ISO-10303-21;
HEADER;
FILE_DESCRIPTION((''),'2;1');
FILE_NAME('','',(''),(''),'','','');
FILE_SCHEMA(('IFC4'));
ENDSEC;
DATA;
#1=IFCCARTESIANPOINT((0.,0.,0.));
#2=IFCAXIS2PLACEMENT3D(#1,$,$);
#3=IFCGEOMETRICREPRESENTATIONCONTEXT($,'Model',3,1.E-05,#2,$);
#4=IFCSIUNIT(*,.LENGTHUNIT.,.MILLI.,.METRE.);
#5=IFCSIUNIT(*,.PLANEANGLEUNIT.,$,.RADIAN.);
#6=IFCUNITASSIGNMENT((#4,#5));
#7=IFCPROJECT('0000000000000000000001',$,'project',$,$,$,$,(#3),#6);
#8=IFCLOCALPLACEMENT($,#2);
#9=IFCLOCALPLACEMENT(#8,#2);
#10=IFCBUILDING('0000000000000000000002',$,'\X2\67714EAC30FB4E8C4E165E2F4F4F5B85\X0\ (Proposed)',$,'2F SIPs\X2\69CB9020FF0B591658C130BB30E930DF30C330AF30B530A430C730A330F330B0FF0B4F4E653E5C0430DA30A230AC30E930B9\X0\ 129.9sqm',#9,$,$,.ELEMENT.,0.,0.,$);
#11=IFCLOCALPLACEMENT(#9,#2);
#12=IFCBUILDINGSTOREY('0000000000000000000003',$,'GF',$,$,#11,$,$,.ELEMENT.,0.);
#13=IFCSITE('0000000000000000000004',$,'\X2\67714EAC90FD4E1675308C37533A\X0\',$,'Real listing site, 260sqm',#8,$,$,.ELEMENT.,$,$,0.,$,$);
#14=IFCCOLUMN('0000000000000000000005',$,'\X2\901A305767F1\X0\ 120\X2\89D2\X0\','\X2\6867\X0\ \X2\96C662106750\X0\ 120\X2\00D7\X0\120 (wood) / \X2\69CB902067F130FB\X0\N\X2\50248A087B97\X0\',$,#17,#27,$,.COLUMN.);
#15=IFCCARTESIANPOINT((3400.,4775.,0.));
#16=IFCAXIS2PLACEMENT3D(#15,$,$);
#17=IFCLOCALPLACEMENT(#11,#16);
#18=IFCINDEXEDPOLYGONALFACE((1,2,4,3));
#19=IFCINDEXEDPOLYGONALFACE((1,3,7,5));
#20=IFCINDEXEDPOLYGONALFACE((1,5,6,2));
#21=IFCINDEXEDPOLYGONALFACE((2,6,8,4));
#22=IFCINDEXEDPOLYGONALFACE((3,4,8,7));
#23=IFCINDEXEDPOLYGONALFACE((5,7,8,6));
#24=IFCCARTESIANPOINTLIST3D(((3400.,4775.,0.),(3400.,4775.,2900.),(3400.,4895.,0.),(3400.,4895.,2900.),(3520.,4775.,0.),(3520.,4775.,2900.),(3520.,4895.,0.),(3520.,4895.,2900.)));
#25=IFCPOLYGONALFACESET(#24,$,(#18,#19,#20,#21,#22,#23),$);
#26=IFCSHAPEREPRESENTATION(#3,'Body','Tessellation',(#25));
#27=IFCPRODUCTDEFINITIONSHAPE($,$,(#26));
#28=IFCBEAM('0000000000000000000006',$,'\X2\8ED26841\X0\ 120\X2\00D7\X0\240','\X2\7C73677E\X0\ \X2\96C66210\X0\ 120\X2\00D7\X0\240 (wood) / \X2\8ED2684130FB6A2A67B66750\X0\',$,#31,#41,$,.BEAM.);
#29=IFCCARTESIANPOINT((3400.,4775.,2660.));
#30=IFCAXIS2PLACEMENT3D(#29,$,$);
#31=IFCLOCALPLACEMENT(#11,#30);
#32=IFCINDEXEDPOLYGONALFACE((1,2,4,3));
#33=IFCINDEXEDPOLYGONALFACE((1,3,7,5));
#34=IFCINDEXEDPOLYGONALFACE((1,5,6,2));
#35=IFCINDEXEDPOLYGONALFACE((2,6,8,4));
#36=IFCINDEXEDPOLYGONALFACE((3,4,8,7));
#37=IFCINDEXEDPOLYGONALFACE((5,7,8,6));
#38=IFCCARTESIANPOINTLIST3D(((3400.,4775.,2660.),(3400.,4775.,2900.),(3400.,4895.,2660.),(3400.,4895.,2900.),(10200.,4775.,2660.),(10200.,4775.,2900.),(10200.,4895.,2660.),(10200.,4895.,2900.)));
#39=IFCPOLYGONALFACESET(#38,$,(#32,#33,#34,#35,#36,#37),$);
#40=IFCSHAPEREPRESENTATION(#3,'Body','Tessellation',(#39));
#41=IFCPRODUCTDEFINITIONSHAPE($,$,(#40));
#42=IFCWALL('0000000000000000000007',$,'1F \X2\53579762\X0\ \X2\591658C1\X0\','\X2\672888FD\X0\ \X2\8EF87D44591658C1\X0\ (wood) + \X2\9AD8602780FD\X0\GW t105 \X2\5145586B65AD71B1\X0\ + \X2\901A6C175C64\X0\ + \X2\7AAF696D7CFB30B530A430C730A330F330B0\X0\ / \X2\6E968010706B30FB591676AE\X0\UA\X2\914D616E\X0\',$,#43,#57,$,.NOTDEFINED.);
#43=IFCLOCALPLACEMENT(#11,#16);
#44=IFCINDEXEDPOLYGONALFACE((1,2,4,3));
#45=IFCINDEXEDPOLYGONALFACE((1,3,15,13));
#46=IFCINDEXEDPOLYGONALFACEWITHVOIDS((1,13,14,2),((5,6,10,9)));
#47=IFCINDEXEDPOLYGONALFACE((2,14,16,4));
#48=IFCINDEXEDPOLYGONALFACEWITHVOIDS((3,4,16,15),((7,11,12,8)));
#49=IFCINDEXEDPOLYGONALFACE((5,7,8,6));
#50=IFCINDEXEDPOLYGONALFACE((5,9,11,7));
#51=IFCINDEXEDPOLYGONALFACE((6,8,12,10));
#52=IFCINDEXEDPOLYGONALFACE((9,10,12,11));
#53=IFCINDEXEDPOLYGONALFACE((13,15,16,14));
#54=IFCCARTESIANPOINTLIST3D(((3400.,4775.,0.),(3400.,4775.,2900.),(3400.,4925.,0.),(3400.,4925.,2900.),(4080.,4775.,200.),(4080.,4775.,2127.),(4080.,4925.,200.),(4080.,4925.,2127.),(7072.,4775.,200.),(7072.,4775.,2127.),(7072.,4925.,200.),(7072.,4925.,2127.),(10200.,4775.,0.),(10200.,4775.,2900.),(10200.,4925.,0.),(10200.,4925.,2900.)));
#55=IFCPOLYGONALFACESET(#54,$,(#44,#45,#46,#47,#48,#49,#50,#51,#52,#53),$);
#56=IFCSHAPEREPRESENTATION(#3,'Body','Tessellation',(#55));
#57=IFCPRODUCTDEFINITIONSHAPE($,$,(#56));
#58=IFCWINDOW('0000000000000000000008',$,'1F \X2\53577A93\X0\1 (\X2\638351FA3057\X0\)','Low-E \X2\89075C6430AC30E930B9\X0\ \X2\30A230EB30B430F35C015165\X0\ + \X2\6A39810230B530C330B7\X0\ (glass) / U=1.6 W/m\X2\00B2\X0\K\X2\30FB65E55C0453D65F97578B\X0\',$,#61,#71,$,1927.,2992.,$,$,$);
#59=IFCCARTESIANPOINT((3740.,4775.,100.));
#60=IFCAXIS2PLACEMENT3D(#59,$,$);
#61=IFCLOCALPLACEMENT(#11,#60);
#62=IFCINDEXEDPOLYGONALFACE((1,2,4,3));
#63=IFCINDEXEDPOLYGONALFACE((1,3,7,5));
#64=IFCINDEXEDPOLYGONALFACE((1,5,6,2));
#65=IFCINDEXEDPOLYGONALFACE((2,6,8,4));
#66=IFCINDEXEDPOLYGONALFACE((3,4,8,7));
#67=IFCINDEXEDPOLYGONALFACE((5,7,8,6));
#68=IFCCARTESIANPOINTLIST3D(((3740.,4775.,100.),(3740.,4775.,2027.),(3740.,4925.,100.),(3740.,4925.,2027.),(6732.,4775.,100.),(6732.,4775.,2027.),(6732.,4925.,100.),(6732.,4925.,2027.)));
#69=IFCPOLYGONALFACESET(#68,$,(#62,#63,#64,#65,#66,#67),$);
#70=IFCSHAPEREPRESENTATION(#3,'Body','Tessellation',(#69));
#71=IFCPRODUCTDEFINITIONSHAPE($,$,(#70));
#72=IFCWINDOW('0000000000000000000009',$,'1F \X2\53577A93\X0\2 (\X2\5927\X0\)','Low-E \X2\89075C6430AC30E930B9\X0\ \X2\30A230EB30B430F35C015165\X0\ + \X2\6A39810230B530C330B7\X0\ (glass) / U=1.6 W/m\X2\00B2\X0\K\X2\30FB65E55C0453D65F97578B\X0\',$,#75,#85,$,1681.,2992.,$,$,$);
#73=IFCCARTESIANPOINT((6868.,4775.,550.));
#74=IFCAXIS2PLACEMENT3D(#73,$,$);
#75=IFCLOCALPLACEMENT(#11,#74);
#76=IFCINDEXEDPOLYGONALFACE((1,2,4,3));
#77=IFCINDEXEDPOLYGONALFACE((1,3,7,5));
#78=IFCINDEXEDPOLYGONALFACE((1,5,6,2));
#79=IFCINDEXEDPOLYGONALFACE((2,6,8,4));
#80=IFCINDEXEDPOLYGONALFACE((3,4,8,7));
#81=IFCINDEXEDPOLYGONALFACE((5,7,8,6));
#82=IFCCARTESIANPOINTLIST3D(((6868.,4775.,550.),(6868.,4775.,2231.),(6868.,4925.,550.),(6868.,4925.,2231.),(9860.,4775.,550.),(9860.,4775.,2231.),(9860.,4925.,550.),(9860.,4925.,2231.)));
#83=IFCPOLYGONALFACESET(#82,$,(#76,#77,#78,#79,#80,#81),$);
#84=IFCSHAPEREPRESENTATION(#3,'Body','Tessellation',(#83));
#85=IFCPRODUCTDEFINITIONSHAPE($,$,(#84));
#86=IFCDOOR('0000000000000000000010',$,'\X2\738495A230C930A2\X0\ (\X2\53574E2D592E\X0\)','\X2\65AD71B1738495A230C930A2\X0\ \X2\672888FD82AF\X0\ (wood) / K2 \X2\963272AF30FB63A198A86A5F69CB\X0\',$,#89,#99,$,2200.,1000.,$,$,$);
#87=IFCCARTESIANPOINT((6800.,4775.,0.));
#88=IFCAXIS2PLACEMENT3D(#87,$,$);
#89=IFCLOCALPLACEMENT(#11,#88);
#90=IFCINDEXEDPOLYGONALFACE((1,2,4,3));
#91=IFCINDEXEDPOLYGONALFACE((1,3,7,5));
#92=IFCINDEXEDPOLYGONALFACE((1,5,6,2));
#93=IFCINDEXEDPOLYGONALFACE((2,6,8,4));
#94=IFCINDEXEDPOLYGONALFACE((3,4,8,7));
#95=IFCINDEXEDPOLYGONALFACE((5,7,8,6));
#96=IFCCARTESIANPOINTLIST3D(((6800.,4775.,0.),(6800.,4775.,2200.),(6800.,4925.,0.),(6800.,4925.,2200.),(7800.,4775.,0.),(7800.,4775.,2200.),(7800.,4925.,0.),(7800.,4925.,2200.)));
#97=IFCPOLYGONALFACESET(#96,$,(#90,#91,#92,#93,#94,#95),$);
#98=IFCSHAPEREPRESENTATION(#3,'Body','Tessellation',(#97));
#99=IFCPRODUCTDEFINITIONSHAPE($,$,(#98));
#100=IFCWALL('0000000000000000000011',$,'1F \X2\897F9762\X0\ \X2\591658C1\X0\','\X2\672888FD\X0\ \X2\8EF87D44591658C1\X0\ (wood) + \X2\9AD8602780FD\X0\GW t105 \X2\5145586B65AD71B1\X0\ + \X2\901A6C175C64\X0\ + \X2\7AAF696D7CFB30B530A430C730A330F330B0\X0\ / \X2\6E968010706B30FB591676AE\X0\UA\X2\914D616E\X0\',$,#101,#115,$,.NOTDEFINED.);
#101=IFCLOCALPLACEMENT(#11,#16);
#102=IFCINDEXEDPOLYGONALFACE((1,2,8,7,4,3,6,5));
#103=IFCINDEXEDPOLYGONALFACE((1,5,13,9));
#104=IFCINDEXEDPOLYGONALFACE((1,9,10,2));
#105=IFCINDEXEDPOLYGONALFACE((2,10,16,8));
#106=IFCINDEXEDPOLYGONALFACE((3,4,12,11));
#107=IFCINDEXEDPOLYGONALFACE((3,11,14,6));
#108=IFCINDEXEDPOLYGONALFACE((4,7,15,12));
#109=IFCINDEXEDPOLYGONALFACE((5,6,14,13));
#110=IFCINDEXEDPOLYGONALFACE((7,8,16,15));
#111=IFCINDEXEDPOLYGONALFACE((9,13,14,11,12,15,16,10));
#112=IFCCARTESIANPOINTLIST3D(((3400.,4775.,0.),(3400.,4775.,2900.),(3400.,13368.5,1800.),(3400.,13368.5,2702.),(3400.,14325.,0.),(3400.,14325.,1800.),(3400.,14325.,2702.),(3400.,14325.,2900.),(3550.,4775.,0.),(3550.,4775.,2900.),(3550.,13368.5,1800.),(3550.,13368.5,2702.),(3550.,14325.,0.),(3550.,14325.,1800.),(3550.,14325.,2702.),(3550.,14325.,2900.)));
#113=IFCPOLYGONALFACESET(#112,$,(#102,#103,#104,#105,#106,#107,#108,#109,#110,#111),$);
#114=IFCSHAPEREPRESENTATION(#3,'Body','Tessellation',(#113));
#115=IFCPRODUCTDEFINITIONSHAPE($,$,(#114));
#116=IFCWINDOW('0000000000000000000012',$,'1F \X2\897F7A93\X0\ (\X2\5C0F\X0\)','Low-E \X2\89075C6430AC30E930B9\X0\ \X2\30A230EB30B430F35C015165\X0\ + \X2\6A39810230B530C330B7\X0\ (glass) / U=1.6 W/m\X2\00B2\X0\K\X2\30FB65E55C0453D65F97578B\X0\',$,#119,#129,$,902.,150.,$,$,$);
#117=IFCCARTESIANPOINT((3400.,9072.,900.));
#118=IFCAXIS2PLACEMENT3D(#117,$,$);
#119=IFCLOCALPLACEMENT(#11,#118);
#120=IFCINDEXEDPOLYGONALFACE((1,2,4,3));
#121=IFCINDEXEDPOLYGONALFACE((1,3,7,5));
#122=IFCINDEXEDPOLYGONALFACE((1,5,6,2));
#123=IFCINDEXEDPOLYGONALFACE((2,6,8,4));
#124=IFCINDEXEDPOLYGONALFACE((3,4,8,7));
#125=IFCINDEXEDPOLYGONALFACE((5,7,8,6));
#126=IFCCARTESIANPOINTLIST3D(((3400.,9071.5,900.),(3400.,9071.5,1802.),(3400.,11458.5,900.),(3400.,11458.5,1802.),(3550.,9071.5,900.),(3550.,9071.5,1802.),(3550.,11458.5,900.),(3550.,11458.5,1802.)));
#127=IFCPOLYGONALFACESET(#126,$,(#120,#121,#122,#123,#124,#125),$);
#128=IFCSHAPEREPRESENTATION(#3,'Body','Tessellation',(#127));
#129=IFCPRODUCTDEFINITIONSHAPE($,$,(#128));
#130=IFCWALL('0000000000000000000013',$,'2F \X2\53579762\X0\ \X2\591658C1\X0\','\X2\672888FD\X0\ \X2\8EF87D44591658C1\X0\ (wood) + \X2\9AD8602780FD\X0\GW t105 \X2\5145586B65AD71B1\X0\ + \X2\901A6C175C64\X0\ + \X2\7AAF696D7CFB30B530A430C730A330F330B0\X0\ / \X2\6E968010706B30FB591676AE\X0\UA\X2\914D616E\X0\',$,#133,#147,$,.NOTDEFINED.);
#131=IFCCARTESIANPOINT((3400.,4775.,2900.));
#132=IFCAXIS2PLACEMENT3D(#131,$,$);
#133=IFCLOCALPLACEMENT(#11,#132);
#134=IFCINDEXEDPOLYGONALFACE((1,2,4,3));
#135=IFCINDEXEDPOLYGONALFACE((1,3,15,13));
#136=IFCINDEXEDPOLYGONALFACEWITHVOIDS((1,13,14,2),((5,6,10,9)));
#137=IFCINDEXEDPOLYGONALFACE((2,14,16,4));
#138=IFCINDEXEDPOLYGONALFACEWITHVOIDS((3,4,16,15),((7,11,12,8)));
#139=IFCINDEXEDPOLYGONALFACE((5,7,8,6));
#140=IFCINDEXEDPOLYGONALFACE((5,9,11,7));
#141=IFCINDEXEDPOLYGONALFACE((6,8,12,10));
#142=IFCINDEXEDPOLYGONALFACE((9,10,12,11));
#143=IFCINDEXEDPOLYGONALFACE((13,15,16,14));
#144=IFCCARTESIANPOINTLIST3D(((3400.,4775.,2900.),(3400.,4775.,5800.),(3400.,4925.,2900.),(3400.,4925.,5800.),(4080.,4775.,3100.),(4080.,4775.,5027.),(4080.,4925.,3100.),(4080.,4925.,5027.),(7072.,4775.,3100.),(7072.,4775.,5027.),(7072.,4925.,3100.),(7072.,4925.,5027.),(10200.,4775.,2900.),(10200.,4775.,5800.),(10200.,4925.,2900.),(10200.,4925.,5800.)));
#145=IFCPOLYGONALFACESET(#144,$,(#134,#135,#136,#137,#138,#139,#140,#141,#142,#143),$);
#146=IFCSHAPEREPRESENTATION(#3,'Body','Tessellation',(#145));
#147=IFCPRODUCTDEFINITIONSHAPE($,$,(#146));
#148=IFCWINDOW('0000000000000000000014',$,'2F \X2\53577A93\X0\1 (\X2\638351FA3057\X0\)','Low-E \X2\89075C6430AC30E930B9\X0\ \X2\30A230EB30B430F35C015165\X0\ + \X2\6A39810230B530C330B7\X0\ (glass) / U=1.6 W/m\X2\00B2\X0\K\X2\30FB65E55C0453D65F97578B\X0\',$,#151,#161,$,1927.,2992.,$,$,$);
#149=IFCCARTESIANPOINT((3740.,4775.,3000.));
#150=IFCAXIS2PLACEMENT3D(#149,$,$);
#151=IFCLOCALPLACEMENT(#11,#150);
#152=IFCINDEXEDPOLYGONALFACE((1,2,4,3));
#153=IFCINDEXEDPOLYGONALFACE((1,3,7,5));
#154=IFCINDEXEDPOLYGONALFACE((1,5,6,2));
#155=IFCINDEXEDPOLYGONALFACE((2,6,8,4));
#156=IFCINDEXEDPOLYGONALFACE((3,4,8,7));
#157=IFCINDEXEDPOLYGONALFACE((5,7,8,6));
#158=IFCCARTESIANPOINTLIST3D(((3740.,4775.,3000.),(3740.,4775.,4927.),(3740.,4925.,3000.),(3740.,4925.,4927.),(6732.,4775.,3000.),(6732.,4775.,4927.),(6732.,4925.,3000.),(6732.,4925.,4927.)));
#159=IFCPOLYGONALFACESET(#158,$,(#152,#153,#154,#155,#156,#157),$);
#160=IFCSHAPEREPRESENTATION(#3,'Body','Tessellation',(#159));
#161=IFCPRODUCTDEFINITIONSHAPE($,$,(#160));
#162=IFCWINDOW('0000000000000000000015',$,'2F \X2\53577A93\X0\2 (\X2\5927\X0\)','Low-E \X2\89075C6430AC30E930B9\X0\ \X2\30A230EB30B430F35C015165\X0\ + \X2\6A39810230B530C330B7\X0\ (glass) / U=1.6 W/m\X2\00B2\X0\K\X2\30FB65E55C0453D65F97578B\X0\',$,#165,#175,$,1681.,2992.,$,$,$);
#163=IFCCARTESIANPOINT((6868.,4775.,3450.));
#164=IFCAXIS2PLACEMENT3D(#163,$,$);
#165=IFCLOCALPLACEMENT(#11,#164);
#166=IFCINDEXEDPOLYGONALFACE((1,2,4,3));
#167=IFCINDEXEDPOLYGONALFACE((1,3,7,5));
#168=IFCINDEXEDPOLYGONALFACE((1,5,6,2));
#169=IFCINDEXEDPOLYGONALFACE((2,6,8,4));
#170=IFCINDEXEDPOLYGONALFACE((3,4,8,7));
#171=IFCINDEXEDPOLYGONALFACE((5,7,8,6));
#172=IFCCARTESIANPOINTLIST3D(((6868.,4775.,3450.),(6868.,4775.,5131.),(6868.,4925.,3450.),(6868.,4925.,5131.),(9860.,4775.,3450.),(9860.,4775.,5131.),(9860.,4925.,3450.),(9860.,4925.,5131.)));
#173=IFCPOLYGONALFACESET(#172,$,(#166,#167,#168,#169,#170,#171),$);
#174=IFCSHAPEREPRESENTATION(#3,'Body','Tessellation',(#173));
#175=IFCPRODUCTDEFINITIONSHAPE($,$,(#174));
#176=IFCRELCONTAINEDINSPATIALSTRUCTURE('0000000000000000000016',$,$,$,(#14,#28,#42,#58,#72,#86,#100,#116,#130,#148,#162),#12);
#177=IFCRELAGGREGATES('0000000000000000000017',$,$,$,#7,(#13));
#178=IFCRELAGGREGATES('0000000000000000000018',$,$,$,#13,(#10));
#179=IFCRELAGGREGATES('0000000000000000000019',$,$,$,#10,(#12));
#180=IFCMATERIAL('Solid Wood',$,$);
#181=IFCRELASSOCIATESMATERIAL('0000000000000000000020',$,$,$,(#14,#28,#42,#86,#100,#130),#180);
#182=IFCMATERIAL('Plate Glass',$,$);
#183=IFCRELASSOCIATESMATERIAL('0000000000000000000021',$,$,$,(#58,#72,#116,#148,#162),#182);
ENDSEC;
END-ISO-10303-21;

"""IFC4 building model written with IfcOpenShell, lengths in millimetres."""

from ifc_helpers import new_model, si_unit, frame, frame_2d, origin, place, context, project, spatial, rectangle, extrude, material, element, fill, save


model = new_model("IFC4")

# Units and contexts
model_context = context("Model", 3, precision=1e-05, world=origin())
ifc_project = project(units=[si_unit("LENGTHUNIT", "METRE", prefix="MILLI"), si_unit("PLANEANGLEUNIT", "RADIAN")], contexts=[model_context])

# Site, building, storey
site_placement = place(None, origin())
site = spatial("IfcSite", under=ifc_project, at=site_placement, Name="東京都世田谷区", ObjectType="Real listing site, 260sqm", CompositionType="ELEMENT", RefElevation=0.0)
building_placement = place(site_placement, origin())
building = spatial("IfcBuilding", under=site, at=building_placement, Name="東京・二世帯住宅 (Proposed)", ObjectType="2F SIPs構造＋外壁セラミックサイディング＋低放射ペアガラス 129.9sqm", CompositionType="ELEMENT", ElevationOfRefHeight=0.0, ElevationOfTerrain=0.0)
storey_placement = place(building_placement, origin())
storey = spatial("IfcBuildingStorey", under=building, at=storey_placement, Name="GF", CompositionType="ELEMENT", Elevation=0.0)

# Column
ifc_material_1 = material(Name="Solid Wood")
column_placement = place(storey_placement, frame((3400.0, 4775.0, 0.0)))
element("IfcColumn", 1, at=column_placement, inside=storey, material=ifc_material_1, Name="通し柱 120角", Description="桧 集成材 120×120 (wood) / 構造柱・N値計算", PredefinedType="COLUMN", context=model_context, shape_type="SweptSolid", body=[
    extrude(rectangle(XDim=120.0, YDim=120.0, at=frame_2d((60.0, 60.0))), frame((3400.0, 4775.0, 0.0)), (0.0, 0.0, 1.0), 2900.0),
])

# Beam
beam_1_placement = place(storey_placement, frame((3400.0, 4775.0, 2660.0)))
element("IfcBeam", 2, at=beam_1_placement, inside=storey, material=ifc_material_1, Name="軒桁 120×240", Description="米松 集成 120×240 (wood) / 軒桁・横架材", PredefinedType="BEAM", context=model_context, shape_type="SweptSolid", body=[
    extrude(rectangle(XDim=6800.0, YDim=120.0, at=frame_2d((3400.0, 60.0))), frame((3400.0, 4775.0, 2660.0)), (0.0, 0.0, 1.0), 240.0),
])

# Wall, openings, windows, door
wall_1_placement = place(storey_placement, frame((3400.0, 4775.0, 0.0)))
wall_1 = element("IfcWall", 3, at=wall_1_placement, inside=storey, material=ifc_material_1, Name="1F 南面 外壁", Description="木製 軸組外壁 (wood) + 高性能GW t105 充填断熱 + 通気層 + 窯業系サイディング / 準耐火・外皮UA配慮", PredefinedType="NOTDEFINED", context=model_context, shape_type="SweptSolid", body=[
    extrude(rectangle(XDim=6800.0, YDim=150.0, at=frame_2d((3400.0, 75.0))), frame((3400.0, 4775.0, 0.0)), (0.0, 0.0, 1.0), 2900.0),
])
opening_1_placement = place(storey_placement, frame((3740.0, 4775.0, 100.0)))
opening_1 = element("IfcOpeningElement", 4, at=opening_1_placement, cuts=wall_1, PredefinedType="NOTDEFINED", context=model_context, shape_type="SweptSolid", body=[
    extrude(rectangle(XDim=2992.0, YDim=150.0, at=frame_2d((1496.0, 75.0))), frame((3740.0, 4775.0, 100.0)), (0.0, 0.0, 1.0), 1927.0),
])
opening_2_placement = place(storey_placement, frame((6868.0, 4775.0, 550.0)))
opening_2 = element("IfcOpeningElement", 5, at=opening_2_placement, cuts=wall_1, PredefinedType="NOTDEFINED", context=model_context, shape_type="SweptSolid", body=[
    extrude(rectangle(XDim=2992.0, YDim=150.0, at=frame_2d((1496.0, 75.0))), frame((6868.0, 4775.0, 550.0)), (0.0, 0.0, 1.0), 1681.0),
])
opening_3_placement = place(storey_placement, frame((6800.0, 4775.0, 0.0)))
opening_3 = element("IfcOpeningElement", 6, at=opening_3_placement, cuts=wall_1, PredefinedType="NOTDEFINED", context=model_context, shape_type="SweptSolid", body=[
    extrude(rectangle(XDim=1000.0, YDim=150.0, at=frame_2d((500.0, 75.0))), frame((6800.0, 4775.0, 0.0)), (0.0, 0.0, 1.0), 2200.0),
])
ifc_material_2 = material(Name="Plate Glass")
window_1_placement = place(storey_placement, frame((3740.0, 4775.0, 100.0)))
window_1 = element("IfcWindow", 7, at=window_1_placement, inside=storey, material=ifc_material_2, Name="1F 南窓1 (掃出し)", Description="Low-E 複層ガラス アルゴン封入 + 樹脂サッシ (glass) / U=1.6 W/m²K・日射取得型", OverallHeight=1927.0, OverallWidth=2992.0, context=model_context, shape_type="SweptSolid", body=[
    extrude(rectangle(XDim=2992.0, YDim=150.0, at=frame_2d((1496.0, 75.0))), frame((3740.0, 4775.0, 100.0)), (0.0, 0.0, 1.0), 1927.0),
])
fill(opening_1, window_1)
window_2_placement = place(storey_placement, frame((6868.0, 4775.0, 550.0)))
window_2 = element("IfcWindow", 8, at=window_2_placement, inside=storey, material=ifc_material_2, Name="1F 南窓2 (大)", Description="Low-E 複層ガラス アルゴン封入 + 樹脂サッシ (glass) / U=1.6 W/m²K・日射取得型", OverallHeight=1681.0, OverallWidth=2992.0, context=model_context, shape_type="SweptSolid", body=[
    extrude(rectangle(XDim=2992.0, YDim=150.0, at=frame_2d((1496.0, 75.0))), frame((6868.0, 4775.0, 550.0)), (0.0, 0.0, 1.0), 1681.0),
])
fill(opening_2, window_2)
door_placement = place(storey_placement, frame((6800.0, 4775.0, 0.0)))
door = element("IfcDoor", 9, at=door_placement, inside=storey, material=ifc_material_1, Name="玄関ドア (南中央)", Description="断熱玄関ドア 木製芯 (wood) / K2 防犯・採風機構", OverallHeight=2200.0, OverallWidth=1000.0, context=model_context, shape_type="SweptSolid", body=[
    extrude(rectangle(XDim=1000.0, YDim=150.0, at=frame_2d((500.0, 75.0))), frame((6800.0, 4775.0, 0.0)), (0.0, 0.0, 1.0), 2200.0),
])
fill(opening_3, door)

# Wall, opening, window
wall_2_placement = place(storey_placement, frame((3400.0, 4775.0, 0.0)))
wall_2 = element("IfcWall", 10, at=wall_2_placement, inside=storey, material=ifc_material_1, Name="1F 西面 外壁", Description="木製 軸組外壁 (wood) + 高性能GW t105 充填断熱 + 通気層 + 窯業系サイディング / 準耐火・外皮UA配慮", PredefinedType="NOTDEFINED", context=model_context, shape_type="SweptSolid", body=[
    extrude(rectangle(XDim=150.0, YDim=9550.0, at=frame_2d((75.0, 4775.0))), frame((3400.0, 4775.0, 0.0)), (0.0, 0.0, 1.0), 2900.0),
])
opening_4_placement = place(storey_placement, frame((3400.0, 9072.0, 900.0)))
opening_4 = element("IfcOpeningElement", 11, at=opening_4_placement, cuts=wall_2, PredefinedType="NOTDEFINED", context=model_context, shape_type="SweptSolid", body=[
    extrude(rectangle(XDim=150.0, YDim=2387.0, at=frame_2d((75.0, 1193.0))), frame((3400.0, 9072.0, 900.0)), (0.0, 0.0, 1.0), 902.0),
])
window_3_placement = place(storey_placement, frame((3400.0, 9072.0, 900.0)))
window_3 = element("IfcWindow", 12, at=window_3_placement, inside=storey, material=ifc_material_2, Name="1F 西窓 (小)", Description="Low-E 複層ガラス アルゴン封入 + 樹脂サッシ (glass) / U=1.6 W/m²K・日射取得型", OverallHeight=902.0, OverallWidth=150.0, context=model_context, shape_type="SweptSolid", body=[
    extrude(rectangle(XDim=150.0, YDim=2387.0, at=frame_2d((75.0, 1193.0))), frame((3400.0, 9072.0, 900.0)), (0.0, 0.0, 1.0), 902.0),
])
fill(opening_4, window_3)

# Wall, openings, windows
wall_3_placement = place(storey_placement, frame((3400.0, 4775.0, 2900.0)))
wall_3 = element("IfcWall", 13, at=wall_3_placement, inside=storey, material=ifc_material_1, Name="2F 南面 外壁", Description="木製 軸組外壁 (wood) + 高性能GW t105 充填断熱 + 通気層 + 窯業系サイディング / 準耐火・外皮UA配慮", PredefinedType="NOTDEFINED", context=model_context, shape_type="SweptSolid", body=[
    extrude(rectangle(XDim=6800.0, YDim=150.0, at=frame_2d((3400.0, 75.0))), frame((3400.0, 4775.0, 2900.0)), (0.0, 0.0, 1.0), 2900.0),
])
opening_5_placement = place(storey_placement, frame((3740.0, 4775.0, 3000.0)))
opening_5 = element("IfcOpeningElement", 14, at=opening_5_placement, cuts=wall_3, PredefinedType="NOTDEFINED", context=model_context, shape_type="SweptSolid", body=[
    extrude(rectangle(XDim=2992.0, YDim=150.0, at=frame_2d((1496.0, 75.0))), frame((3740.0, 4775.0, 3000.0)), (0.0, 0.0, 1.0), 1927.0),
])
opening_6_placement = place(storey_placement, frame((6868.0, 4775.0, 3450.0)))
opening_6 = element("IfcOpeningElement", 15, at=opening_6_placement, cuts=wall_3, PredefinedType="NOTDEFINED", context=model_context, shape_type="SweptSolid", body=[
    extrude(rectangle(XDim=2992.0, YDim=150.0, at=frame_2d((1496.0, 75.0))), frame((6868.0, 4775.0, 3450.0)), (0.0, 0.0, 1.0), 1681.0),
])
window_4_placement = place(storey_placement, frame((3740.0, 4775.0, 3000.0)))
window_4 = element("IfcWindow", 16, at=window_4_placement, inside=storey, material=ifc_material_2, Name="2F 南窓1 (掃出し)", Description="Low-E 複層ガラス アルゴン封入 + 樹脂サッシ (glass) / U=1.6 W/m²K・日射取得型", OverallHeight=1927.0, OverallWidth=2992.0, context=model_context, shape_type="SweptSolid", body=[
    extrude(rectangle(XDim=2992.0, YDim=150.0, at=frame_2d((1496.0, 75.0))), frame((3740.0, 4775.0, 3000.0)), (0.0, 0.0, 1.0), 1927.0),
])
fill(opening_5, window_4)
window_5_placement = place(storey_placement, frame((6868.0, 4775.0, 3450.0)))
window_5 = element("IfcWindow", 17, at=window_5_placement, inside=storey, material=ifc_material_2, Name="2F 南窓2 (大)", Description="Low-E 複層ガラス アルゴン封入 + 樹脂サッシ (glass) / U=1.6 W/m²K・日射取得型", OverallHeight=1681.0, OverallWidth=2992.0, context=model_context, shape_type="SweptSolid", body=[
    extrude(rectangle(XDim=2992.0, YDim=150.0, at=frame_2d((1496.0, 75.0))), frame((6868.0, 4775.0, 3450.0)), (0.0, 0.0, 1.0), 1681.0),
])
fill(opening_6, window_5)

save(model, "model.ifc")
